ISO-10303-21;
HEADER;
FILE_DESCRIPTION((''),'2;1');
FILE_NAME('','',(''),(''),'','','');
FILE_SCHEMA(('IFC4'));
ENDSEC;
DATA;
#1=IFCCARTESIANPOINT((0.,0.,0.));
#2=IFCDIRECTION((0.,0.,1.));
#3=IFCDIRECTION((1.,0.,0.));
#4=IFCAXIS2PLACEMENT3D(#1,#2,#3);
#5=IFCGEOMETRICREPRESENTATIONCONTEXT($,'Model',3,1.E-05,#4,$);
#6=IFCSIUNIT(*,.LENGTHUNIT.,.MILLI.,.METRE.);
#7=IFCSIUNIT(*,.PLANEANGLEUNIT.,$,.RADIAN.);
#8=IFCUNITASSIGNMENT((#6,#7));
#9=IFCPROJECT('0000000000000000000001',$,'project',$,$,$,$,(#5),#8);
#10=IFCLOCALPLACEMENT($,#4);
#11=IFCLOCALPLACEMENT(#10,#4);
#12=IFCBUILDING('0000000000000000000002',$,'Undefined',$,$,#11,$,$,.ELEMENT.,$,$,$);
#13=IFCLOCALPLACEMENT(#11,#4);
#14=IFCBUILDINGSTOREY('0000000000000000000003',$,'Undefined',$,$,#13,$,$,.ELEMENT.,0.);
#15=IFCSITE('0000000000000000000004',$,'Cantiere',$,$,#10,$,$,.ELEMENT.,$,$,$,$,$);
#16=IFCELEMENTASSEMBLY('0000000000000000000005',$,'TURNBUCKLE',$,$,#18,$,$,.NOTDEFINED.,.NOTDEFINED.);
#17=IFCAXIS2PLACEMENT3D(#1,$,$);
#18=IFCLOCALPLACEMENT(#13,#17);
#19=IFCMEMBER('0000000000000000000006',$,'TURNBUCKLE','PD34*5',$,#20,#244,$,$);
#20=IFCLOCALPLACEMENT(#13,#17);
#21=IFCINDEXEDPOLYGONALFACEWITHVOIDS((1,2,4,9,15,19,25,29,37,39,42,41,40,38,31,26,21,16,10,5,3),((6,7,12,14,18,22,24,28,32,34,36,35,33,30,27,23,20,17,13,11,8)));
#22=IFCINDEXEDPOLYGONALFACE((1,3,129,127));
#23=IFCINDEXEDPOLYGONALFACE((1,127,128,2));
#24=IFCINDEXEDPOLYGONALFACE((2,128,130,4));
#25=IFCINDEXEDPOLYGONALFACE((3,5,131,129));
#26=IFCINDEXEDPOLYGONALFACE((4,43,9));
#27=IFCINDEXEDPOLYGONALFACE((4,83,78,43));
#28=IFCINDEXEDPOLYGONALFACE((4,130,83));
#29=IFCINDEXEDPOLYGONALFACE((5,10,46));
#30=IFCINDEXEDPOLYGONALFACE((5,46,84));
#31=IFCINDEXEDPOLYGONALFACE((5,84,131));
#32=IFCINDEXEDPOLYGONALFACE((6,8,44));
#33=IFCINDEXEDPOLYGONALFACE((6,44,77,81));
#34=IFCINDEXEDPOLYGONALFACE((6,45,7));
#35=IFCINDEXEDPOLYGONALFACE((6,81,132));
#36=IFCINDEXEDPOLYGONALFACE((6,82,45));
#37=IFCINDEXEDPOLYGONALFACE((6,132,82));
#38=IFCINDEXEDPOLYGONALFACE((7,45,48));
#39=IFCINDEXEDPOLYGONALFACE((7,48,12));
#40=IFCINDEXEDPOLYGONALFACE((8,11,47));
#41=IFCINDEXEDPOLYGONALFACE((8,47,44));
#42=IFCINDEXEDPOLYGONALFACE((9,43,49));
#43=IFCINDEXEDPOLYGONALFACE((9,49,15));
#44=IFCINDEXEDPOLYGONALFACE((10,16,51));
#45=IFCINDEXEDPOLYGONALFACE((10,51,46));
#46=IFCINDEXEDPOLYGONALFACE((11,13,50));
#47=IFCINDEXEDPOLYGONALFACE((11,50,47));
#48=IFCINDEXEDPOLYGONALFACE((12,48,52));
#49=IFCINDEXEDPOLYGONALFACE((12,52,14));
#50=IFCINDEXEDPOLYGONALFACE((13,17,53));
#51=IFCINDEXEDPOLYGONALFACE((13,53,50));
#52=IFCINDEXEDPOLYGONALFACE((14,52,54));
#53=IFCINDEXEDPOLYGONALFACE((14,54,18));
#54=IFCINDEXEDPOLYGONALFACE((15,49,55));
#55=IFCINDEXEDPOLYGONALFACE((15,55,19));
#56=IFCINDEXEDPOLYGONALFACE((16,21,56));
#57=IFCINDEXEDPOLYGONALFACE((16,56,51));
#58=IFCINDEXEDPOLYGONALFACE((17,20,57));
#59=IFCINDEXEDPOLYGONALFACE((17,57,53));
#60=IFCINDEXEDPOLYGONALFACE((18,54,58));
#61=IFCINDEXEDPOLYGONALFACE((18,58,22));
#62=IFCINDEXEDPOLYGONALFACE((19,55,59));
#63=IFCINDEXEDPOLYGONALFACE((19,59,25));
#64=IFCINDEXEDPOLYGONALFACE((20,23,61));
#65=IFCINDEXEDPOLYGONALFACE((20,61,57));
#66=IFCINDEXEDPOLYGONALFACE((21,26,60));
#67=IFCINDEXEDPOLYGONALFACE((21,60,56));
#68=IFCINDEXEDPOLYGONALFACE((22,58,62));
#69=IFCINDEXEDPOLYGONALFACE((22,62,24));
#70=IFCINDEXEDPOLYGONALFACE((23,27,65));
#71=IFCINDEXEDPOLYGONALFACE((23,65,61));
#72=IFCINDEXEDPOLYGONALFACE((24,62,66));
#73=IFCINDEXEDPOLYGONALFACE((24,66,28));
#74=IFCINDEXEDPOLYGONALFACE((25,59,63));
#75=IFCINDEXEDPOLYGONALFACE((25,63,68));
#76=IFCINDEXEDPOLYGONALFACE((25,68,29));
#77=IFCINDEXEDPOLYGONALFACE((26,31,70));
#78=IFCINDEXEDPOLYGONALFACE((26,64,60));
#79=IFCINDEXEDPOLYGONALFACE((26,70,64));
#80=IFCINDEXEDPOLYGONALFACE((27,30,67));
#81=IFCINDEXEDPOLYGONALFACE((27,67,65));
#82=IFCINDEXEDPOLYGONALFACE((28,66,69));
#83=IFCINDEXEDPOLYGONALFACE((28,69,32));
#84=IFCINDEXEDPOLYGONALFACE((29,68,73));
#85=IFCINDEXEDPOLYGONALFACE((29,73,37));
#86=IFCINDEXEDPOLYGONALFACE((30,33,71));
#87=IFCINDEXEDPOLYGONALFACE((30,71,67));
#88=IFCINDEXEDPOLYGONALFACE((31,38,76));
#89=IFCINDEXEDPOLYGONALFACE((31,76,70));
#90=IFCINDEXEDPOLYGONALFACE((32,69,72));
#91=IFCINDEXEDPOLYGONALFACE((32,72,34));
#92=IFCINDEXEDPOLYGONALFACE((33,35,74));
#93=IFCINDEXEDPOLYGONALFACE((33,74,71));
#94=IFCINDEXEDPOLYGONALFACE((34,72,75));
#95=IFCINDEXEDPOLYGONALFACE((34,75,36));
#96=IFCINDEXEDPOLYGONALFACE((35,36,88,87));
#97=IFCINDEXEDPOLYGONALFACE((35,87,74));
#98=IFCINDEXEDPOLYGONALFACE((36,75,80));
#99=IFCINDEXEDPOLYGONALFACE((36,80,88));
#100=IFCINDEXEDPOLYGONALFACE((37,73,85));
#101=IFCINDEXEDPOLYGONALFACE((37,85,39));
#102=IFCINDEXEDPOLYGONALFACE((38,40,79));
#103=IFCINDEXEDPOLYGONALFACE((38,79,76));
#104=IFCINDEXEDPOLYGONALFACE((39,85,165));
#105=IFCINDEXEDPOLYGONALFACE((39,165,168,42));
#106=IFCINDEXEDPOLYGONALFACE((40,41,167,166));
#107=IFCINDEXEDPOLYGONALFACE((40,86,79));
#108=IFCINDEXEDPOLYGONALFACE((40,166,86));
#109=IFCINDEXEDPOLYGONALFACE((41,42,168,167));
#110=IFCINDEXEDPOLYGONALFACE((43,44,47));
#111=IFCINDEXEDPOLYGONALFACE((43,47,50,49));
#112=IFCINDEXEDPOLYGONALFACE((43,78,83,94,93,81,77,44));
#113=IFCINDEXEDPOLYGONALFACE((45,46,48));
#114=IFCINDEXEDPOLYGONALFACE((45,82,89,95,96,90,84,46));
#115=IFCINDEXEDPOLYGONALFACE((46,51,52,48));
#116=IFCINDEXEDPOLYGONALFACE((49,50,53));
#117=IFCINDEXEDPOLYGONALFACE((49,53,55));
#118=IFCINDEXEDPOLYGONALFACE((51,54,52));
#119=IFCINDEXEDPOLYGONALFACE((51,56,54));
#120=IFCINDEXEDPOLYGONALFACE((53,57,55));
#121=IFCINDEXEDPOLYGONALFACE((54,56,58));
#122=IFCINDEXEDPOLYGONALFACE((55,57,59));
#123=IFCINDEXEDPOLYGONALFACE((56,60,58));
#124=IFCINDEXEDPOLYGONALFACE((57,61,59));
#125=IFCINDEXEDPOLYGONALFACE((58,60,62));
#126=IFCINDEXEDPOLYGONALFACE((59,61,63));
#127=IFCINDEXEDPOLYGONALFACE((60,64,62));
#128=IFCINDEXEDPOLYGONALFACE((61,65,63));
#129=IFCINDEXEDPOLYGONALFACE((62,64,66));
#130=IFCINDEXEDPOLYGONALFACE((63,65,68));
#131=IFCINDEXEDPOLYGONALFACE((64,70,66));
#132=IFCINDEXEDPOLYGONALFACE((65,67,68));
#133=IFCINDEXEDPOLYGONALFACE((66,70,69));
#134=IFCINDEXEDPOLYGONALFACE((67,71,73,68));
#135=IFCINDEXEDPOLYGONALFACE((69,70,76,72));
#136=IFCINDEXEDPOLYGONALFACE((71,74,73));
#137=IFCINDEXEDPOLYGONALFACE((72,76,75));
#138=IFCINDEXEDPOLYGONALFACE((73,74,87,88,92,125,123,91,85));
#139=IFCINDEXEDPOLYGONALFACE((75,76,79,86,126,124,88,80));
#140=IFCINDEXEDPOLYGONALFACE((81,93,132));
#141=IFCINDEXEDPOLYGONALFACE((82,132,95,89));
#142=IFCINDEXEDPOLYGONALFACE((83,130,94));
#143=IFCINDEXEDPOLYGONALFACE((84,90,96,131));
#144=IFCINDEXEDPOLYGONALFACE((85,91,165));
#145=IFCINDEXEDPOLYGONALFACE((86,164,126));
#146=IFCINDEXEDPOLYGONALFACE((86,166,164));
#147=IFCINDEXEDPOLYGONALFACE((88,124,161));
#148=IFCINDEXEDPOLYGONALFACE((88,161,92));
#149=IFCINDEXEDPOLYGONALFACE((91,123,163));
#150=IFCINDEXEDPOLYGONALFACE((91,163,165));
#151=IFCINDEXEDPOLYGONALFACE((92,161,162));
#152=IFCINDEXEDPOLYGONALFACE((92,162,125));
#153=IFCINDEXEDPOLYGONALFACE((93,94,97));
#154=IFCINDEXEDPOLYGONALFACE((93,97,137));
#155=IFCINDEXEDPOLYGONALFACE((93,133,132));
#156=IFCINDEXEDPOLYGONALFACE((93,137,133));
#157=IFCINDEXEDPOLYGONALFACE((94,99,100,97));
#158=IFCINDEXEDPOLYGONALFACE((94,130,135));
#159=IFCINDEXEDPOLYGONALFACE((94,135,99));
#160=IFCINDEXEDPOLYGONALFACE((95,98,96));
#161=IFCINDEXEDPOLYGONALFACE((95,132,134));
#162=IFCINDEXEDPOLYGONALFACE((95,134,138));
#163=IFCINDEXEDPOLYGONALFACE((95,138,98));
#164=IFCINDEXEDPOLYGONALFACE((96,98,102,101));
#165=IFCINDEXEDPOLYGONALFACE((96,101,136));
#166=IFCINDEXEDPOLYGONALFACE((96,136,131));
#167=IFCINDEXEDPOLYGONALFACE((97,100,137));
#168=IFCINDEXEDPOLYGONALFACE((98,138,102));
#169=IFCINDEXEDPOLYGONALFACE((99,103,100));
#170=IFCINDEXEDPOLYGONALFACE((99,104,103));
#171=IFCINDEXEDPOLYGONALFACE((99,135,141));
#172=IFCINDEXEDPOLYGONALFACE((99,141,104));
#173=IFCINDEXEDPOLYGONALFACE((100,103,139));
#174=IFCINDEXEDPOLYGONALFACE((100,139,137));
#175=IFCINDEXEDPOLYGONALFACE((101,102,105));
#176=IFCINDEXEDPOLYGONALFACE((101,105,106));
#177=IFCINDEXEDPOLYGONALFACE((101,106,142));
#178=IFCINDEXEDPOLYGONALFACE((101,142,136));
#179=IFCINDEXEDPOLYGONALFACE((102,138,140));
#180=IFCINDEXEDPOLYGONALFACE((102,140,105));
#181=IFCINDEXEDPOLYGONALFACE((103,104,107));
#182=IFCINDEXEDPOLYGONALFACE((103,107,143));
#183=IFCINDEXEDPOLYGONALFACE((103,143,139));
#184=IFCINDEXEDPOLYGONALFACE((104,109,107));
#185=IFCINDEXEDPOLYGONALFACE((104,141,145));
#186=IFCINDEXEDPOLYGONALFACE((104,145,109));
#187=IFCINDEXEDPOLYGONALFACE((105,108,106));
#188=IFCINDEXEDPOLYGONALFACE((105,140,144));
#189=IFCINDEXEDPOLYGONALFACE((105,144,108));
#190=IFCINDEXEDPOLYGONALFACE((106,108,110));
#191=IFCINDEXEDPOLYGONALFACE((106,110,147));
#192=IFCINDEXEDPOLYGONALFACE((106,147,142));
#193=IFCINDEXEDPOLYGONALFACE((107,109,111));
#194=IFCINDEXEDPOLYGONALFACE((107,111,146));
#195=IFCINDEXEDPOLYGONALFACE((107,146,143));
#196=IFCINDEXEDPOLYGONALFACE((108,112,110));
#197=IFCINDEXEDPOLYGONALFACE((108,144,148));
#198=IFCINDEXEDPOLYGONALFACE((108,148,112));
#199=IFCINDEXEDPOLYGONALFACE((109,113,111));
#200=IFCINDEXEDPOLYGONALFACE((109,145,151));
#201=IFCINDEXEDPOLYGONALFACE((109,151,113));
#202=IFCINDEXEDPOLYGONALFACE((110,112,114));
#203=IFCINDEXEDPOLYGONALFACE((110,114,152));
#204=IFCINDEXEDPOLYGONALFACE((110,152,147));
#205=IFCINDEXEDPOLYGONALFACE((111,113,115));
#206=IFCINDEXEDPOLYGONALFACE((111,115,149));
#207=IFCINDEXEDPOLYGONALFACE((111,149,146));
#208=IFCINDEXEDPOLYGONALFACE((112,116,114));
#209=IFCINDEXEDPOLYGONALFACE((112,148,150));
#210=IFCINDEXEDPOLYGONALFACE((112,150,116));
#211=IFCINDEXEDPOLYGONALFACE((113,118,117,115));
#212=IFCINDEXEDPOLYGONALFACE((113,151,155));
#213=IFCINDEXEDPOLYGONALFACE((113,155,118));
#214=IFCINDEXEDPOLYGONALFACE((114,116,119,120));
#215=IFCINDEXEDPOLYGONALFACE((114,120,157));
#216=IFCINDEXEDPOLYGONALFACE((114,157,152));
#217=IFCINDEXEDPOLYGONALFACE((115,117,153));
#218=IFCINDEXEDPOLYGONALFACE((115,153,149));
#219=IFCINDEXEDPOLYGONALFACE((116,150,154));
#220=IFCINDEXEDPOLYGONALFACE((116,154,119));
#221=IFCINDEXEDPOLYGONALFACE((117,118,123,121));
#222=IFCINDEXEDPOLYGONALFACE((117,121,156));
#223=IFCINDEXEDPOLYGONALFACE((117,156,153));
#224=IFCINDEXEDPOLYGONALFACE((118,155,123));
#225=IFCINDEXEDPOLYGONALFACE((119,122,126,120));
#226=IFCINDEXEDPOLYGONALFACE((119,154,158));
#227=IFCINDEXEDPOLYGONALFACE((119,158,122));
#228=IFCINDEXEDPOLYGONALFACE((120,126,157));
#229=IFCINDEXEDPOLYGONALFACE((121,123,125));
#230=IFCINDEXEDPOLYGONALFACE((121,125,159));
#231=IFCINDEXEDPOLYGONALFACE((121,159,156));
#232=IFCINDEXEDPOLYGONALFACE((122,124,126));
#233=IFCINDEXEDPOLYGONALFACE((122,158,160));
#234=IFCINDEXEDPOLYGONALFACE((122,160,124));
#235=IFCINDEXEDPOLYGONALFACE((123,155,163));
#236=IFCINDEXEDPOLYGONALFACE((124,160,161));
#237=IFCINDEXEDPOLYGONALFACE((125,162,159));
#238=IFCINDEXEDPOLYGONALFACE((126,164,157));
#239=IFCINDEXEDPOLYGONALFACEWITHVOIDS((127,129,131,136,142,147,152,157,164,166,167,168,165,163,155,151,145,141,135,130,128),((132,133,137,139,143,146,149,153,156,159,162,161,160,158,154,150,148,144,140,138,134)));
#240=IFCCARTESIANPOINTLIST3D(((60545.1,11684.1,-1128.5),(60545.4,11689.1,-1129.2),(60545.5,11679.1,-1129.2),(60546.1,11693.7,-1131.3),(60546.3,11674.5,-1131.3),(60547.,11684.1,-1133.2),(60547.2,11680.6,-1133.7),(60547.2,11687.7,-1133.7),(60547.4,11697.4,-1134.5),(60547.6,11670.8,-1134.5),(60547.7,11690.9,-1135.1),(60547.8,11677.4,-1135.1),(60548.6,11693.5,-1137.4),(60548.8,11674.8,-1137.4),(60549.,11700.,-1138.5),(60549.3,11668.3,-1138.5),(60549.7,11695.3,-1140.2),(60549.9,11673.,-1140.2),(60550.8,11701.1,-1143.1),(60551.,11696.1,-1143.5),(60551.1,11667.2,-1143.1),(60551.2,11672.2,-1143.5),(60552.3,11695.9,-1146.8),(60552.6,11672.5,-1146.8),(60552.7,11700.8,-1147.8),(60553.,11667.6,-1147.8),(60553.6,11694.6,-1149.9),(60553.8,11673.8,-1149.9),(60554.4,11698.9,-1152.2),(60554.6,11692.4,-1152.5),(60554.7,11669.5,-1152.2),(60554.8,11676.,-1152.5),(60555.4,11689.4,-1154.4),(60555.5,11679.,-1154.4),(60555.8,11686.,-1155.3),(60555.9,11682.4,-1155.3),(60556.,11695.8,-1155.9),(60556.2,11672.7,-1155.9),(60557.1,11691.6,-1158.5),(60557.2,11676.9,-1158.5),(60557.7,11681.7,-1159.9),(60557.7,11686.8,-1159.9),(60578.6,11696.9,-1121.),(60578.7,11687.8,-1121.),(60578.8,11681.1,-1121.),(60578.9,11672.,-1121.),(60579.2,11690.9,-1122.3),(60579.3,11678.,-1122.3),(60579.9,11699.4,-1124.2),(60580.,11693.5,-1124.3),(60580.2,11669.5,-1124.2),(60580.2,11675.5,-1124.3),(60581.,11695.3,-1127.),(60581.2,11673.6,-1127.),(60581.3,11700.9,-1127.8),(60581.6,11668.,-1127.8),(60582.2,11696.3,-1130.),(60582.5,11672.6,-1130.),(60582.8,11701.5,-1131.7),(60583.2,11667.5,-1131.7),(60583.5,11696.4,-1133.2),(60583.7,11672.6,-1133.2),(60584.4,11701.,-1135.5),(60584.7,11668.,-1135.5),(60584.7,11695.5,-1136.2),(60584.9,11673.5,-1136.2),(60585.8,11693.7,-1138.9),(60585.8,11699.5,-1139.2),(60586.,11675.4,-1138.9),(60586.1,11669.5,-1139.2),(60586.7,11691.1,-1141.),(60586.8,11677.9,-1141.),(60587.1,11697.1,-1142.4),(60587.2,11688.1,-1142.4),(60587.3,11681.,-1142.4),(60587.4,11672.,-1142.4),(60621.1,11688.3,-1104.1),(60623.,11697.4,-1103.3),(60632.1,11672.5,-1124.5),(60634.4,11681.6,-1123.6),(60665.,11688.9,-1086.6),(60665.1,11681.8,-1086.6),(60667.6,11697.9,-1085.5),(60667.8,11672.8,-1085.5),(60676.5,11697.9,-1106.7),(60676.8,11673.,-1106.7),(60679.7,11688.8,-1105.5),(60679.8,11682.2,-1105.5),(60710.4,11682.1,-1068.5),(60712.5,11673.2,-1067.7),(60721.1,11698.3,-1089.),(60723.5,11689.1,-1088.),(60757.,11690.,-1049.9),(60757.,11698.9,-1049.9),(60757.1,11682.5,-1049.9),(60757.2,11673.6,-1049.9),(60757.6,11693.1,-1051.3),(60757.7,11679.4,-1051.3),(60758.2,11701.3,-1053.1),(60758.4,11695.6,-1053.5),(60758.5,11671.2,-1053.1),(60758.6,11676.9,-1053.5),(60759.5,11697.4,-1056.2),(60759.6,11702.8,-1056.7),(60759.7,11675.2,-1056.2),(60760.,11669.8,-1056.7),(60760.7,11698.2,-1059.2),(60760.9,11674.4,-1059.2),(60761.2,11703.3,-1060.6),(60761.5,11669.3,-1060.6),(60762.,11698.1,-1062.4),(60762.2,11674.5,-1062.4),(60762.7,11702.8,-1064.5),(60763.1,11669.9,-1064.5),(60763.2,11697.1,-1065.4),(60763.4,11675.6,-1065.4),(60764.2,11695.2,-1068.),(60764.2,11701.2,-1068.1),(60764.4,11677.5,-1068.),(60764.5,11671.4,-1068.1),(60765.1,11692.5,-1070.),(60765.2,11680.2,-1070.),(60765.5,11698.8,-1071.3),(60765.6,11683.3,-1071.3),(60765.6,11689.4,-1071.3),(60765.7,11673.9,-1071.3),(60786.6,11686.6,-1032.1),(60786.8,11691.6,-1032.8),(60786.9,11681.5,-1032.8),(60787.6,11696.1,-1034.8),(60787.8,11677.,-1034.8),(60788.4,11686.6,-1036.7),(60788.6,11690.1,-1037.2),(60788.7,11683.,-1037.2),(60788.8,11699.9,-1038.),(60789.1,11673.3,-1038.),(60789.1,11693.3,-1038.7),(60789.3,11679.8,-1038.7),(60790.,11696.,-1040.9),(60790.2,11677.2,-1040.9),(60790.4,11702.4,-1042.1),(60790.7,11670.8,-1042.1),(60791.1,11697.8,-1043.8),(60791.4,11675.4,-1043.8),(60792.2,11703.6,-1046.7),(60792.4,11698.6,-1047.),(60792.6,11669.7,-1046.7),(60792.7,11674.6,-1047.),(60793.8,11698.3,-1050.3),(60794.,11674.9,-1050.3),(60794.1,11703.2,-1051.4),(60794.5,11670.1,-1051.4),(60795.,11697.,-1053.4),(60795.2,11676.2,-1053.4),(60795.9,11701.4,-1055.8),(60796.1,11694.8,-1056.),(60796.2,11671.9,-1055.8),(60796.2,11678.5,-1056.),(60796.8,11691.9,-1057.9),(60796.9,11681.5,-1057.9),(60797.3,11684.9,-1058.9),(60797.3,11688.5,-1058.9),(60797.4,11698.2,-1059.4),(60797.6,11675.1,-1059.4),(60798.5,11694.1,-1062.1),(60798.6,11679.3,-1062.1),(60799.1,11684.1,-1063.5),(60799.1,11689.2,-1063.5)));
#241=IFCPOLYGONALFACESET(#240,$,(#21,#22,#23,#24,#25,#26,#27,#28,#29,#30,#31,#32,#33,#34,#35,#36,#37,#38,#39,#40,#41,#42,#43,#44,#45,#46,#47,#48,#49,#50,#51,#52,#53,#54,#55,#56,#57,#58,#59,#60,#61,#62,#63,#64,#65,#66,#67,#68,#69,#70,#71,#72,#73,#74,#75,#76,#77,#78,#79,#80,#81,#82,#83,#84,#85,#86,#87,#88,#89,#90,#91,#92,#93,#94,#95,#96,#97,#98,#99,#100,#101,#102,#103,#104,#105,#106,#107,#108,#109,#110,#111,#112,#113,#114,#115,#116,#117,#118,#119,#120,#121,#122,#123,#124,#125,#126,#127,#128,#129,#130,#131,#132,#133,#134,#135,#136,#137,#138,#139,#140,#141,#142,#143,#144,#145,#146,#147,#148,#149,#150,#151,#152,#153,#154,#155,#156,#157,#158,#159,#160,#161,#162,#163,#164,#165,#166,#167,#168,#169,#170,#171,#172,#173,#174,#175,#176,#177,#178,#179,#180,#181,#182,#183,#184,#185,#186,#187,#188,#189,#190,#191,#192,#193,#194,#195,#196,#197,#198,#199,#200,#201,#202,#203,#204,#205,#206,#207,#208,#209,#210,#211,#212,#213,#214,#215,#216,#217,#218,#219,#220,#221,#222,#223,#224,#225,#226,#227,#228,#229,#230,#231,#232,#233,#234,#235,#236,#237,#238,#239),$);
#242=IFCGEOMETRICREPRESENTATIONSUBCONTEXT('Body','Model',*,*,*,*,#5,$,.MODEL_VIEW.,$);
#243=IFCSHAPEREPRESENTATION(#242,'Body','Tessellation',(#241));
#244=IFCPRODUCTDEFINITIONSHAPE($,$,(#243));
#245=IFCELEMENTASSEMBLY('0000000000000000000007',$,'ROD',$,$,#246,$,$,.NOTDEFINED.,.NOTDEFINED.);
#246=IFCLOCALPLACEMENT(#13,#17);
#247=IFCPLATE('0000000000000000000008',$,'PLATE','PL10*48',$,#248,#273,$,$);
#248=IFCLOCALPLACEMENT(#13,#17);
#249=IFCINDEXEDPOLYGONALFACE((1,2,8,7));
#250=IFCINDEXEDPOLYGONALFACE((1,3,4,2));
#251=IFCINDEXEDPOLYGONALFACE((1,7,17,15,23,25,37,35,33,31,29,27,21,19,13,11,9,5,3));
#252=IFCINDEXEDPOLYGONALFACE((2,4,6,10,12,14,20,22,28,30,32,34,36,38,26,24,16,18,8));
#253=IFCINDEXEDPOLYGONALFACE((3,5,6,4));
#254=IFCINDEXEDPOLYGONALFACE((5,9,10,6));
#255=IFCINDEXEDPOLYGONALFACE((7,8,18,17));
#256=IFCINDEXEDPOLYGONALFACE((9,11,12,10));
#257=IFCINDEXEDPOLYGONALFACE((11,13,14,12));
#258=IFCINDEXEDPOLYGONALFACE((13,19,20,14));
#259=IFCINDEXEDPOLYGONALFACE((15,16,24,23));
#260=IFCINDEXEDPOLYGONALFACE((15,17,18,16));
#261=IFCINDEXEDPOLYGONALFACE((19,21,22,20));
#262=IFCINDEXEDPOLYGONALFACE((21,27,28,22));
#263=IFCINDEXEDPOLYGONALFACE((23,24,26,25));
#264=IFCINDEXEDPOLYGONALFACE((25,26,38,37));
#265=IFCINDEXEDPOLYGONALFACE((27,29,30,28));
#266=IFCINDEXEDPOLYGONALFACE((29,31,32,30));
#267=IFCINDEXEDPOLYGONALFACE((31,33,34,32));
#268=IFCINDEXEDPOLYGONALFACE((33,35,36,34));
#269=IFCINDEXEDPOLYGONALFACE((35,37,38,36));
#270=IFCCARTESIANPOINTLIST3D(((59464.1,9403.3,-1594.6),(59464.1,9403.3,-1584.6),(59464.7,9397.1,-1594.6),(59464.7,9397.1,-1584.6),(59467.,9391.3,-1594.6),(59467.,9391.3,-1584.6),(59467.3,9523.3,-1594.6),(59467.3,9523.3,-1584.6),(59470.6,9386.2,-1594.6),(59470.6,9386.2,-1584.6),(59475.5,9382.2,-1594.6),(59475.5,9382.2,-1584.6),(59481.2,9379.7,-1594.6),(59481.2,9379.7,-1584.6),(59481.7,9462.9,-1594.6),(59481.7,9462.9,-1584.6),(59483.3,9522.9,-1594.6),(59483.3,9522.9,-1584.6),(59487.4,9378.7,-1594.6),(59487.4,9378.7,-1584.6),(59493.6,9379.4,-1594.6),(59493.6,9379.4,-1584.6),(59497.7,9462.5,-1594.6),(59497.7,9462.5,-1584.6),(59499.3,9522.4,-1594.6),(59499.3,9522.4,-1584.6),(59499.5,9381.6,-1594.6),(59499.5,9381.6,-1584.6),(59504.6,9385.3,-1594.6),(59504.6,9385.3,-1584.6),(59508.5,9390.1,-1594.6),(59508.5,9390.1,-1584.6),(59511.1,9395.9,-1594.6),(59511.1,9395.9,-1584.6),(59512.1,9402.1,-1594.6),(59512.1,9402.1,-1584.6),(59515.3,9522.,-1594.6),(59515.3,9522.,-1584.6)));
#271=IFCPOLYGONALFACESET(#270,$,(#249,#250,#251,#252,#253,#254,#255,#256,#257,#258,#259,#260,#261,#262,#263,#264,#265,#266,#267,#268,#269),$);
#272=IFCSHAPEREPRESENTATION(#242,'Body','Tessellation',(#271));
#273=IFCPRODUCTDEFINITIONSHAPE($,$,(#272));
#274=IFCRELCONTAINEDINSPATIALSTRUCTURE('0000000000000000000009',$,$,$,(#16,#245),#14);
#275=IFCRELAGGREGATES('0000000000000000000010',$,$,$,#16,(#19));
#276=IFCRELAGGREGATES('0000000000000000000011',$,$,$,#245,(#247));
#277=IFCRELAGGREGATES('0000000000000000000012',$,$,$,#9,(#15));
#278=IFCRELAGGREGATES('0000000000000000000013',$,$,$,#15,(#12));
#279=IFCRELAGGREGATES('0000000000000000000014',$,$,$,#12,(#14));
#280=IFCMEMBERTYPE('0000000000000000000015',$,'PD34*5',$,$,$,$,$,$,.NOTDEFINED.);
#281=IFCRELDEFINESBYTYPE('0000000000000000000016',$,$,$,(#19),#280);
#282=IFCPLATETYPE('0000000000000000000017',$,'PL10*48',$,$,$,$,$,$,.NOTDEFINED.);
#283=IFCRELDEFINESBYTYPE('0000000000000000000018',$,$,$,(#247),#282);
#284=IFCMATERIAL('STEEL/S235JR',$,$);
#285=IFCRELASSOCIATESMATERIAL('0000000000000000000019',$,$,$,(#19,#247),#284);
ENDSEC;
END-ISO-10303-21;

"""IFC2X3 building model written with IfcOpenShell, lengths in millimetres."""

from ifc_helpers import new_model, si_unit, frame, frame_2d, origin_with_axes, origin_2d_with_axis, place, context, subcontext, project, spatial, polyline, circle_curve, parameter, trimmed, segment, composite_curve, rectangle, hollow_circle, outline, extrude, boolean, material, type_object, element, aggregate, save


model = new_model("IFC2X3")

# Units and contexts
model_context = context("Model", 3, precision=1e-05, world=origin_with_axes())
body_context = subcontext(model_context, "Body", "Model", "MODEL_VIEW")
ifc_project = project(units=[si_unit("LENGTHUNIT", "METRE", prefix="MILLI"), si_unit("PLANEANGLEUNIT", "RADIAN")], contexts=[model_context])

# Site, building, storey
site_placement = place(None, origin_with_axes())
site = spatial("IfcSite", under=ifc_project, at=site_placement, Name="Cantiere", CompositionType="ELEMENT")
building_placement = place(site_placement, origin_with_axes())
building = spatial("IfcBuilding", under=site, at=building_placement, Name="Undefined", CompositionType="ELEMENT")
storey_placement = place(building_placement, origin_with_axes())
storey = spatial("IfcBuildingStorey", under=building, at=storey_placement, Name="Undefined", CompositionType="ELEMENT", Elevation=0.0)

# Shared definitions
ifc_material_1 = material(Name="STEEL/S235JR")

# Element assembly, member
member_type = type_object("IfcMemberType", Name="PD34*5", PredefinedType="NOTDEFINED")
assembly_1_placement = place(storey_placement, origin_with_axes())
assembly_1 = element("IfcElementAssembly", 1, at=assembly_1_placement, inside=storey, Name="TURNBUCKLE", AssemblyPlace="NOTDEFINED", PredefinedType="NOTDEFINED")
member_1_placement = place(assembly_1_placement, frame((60792.9, 11686.6, -1047.9), z_axis=(0.010138, -0.999949, 0.0), x_axis=(-0.92859, -0.009414, -0.370987)))
member_1 = element("IfcMember", 2, at=member_1_placement, type_object=member_type, material=ifc_material_1, Name="TURNBUCKLE", Description="PD34*5", context=body_context, shape_type="CSG", body=[
    boolean("DIFFERENCE", extrude(hollow_circle(Radius=17.0, WallThickness=5.0, at=origin_2d_with_axis()), frame((260.0, 0.0, 0.0), z_axis=(-1.0, 0.0, 0.0), x_axis=(0.0, -1.0, 0.0)), (0.0, 0.0, 1.0), 260.0), extrude(rectangle(XDim=23.0, YDim=68.0, at=origin_2d_with_axis()), frame((226.0, 0.0, 0.0), z_axis=(-1.0, 0.000733, 0.0), x_axis=(-0.000733, -1.0, 0.0)), (0.0, 0.0, 1.0), 192.0)),
])
aggregate(assembly_1, [member_1])

# Element assembly, plate
assembly_2_placement = place(storey_placement, origin_with_axes())
assembly_2 = element("IfcElementAssembly", 3, at=assembly_2_placement, inside=storey, Name="ROD", AssemblyPlace="NOTDEFINED", PredefinedType="NOTDEFINED")
plate_type_1 = type_object("IfcPlateType", Name="PL10*48", PredefinedType="NOTDEFINED")
plate_1_placement = place(assembly_2_placement, frame((59467.3, 9523.3, -1589.6), z_axis=(0.0, 0.0, 1.0), x_axis=(-0.026971, -0.999636, -0.000001)))
plate_1 = element("IfcPlate", 4, at=plate_1_placement, type_object=plate_type_1, material=ifc_material_1, Name="PLATE", Description="PL10*48", context=body_context, shape_type="SweptSolid", body=[
    extrude(outline(composite_curve([segment(polyline([(0.0, 0.0), (120.0, 0.0)]), True, "CONTINUOUS"), segment(trimmed(circle_curve(frame_2d((120.0, 24.0), x_axis=(0.0, -1.0)), 24.0), [parameter(0.0)], [parameter(1.570796)], True, "PARAMETER"), True, "CONTINUOUS"), segment(trimmed(circle_curve(frame_2d((120.0, 24.0), x_axis=(1.0, 0.0)), 24.0), [parameter(0.0)], [parameter(1.570796)], True, "PARAMETER"), True, "CONTINUOUS"), segment(polyline([(120.0, 48.0), (0.0, 48.0), (0.0, 32.0), (60.0, 32.0), (60.0, 16.0), (0.0, 16.0), (0.0, 0.0)]), True, "CONTINUOUS")], self_intersect=True)), frame((0.0, 0.0, -5.0), z_axis=(0.0, 0.0, 1.0), x_axis=(1.0, 0.0, 0.0)), (0.0, 0.0, 1.0), 10.0),
])

aggregate(assembly_2, [plate_1])

save(model, "model.ifc")
